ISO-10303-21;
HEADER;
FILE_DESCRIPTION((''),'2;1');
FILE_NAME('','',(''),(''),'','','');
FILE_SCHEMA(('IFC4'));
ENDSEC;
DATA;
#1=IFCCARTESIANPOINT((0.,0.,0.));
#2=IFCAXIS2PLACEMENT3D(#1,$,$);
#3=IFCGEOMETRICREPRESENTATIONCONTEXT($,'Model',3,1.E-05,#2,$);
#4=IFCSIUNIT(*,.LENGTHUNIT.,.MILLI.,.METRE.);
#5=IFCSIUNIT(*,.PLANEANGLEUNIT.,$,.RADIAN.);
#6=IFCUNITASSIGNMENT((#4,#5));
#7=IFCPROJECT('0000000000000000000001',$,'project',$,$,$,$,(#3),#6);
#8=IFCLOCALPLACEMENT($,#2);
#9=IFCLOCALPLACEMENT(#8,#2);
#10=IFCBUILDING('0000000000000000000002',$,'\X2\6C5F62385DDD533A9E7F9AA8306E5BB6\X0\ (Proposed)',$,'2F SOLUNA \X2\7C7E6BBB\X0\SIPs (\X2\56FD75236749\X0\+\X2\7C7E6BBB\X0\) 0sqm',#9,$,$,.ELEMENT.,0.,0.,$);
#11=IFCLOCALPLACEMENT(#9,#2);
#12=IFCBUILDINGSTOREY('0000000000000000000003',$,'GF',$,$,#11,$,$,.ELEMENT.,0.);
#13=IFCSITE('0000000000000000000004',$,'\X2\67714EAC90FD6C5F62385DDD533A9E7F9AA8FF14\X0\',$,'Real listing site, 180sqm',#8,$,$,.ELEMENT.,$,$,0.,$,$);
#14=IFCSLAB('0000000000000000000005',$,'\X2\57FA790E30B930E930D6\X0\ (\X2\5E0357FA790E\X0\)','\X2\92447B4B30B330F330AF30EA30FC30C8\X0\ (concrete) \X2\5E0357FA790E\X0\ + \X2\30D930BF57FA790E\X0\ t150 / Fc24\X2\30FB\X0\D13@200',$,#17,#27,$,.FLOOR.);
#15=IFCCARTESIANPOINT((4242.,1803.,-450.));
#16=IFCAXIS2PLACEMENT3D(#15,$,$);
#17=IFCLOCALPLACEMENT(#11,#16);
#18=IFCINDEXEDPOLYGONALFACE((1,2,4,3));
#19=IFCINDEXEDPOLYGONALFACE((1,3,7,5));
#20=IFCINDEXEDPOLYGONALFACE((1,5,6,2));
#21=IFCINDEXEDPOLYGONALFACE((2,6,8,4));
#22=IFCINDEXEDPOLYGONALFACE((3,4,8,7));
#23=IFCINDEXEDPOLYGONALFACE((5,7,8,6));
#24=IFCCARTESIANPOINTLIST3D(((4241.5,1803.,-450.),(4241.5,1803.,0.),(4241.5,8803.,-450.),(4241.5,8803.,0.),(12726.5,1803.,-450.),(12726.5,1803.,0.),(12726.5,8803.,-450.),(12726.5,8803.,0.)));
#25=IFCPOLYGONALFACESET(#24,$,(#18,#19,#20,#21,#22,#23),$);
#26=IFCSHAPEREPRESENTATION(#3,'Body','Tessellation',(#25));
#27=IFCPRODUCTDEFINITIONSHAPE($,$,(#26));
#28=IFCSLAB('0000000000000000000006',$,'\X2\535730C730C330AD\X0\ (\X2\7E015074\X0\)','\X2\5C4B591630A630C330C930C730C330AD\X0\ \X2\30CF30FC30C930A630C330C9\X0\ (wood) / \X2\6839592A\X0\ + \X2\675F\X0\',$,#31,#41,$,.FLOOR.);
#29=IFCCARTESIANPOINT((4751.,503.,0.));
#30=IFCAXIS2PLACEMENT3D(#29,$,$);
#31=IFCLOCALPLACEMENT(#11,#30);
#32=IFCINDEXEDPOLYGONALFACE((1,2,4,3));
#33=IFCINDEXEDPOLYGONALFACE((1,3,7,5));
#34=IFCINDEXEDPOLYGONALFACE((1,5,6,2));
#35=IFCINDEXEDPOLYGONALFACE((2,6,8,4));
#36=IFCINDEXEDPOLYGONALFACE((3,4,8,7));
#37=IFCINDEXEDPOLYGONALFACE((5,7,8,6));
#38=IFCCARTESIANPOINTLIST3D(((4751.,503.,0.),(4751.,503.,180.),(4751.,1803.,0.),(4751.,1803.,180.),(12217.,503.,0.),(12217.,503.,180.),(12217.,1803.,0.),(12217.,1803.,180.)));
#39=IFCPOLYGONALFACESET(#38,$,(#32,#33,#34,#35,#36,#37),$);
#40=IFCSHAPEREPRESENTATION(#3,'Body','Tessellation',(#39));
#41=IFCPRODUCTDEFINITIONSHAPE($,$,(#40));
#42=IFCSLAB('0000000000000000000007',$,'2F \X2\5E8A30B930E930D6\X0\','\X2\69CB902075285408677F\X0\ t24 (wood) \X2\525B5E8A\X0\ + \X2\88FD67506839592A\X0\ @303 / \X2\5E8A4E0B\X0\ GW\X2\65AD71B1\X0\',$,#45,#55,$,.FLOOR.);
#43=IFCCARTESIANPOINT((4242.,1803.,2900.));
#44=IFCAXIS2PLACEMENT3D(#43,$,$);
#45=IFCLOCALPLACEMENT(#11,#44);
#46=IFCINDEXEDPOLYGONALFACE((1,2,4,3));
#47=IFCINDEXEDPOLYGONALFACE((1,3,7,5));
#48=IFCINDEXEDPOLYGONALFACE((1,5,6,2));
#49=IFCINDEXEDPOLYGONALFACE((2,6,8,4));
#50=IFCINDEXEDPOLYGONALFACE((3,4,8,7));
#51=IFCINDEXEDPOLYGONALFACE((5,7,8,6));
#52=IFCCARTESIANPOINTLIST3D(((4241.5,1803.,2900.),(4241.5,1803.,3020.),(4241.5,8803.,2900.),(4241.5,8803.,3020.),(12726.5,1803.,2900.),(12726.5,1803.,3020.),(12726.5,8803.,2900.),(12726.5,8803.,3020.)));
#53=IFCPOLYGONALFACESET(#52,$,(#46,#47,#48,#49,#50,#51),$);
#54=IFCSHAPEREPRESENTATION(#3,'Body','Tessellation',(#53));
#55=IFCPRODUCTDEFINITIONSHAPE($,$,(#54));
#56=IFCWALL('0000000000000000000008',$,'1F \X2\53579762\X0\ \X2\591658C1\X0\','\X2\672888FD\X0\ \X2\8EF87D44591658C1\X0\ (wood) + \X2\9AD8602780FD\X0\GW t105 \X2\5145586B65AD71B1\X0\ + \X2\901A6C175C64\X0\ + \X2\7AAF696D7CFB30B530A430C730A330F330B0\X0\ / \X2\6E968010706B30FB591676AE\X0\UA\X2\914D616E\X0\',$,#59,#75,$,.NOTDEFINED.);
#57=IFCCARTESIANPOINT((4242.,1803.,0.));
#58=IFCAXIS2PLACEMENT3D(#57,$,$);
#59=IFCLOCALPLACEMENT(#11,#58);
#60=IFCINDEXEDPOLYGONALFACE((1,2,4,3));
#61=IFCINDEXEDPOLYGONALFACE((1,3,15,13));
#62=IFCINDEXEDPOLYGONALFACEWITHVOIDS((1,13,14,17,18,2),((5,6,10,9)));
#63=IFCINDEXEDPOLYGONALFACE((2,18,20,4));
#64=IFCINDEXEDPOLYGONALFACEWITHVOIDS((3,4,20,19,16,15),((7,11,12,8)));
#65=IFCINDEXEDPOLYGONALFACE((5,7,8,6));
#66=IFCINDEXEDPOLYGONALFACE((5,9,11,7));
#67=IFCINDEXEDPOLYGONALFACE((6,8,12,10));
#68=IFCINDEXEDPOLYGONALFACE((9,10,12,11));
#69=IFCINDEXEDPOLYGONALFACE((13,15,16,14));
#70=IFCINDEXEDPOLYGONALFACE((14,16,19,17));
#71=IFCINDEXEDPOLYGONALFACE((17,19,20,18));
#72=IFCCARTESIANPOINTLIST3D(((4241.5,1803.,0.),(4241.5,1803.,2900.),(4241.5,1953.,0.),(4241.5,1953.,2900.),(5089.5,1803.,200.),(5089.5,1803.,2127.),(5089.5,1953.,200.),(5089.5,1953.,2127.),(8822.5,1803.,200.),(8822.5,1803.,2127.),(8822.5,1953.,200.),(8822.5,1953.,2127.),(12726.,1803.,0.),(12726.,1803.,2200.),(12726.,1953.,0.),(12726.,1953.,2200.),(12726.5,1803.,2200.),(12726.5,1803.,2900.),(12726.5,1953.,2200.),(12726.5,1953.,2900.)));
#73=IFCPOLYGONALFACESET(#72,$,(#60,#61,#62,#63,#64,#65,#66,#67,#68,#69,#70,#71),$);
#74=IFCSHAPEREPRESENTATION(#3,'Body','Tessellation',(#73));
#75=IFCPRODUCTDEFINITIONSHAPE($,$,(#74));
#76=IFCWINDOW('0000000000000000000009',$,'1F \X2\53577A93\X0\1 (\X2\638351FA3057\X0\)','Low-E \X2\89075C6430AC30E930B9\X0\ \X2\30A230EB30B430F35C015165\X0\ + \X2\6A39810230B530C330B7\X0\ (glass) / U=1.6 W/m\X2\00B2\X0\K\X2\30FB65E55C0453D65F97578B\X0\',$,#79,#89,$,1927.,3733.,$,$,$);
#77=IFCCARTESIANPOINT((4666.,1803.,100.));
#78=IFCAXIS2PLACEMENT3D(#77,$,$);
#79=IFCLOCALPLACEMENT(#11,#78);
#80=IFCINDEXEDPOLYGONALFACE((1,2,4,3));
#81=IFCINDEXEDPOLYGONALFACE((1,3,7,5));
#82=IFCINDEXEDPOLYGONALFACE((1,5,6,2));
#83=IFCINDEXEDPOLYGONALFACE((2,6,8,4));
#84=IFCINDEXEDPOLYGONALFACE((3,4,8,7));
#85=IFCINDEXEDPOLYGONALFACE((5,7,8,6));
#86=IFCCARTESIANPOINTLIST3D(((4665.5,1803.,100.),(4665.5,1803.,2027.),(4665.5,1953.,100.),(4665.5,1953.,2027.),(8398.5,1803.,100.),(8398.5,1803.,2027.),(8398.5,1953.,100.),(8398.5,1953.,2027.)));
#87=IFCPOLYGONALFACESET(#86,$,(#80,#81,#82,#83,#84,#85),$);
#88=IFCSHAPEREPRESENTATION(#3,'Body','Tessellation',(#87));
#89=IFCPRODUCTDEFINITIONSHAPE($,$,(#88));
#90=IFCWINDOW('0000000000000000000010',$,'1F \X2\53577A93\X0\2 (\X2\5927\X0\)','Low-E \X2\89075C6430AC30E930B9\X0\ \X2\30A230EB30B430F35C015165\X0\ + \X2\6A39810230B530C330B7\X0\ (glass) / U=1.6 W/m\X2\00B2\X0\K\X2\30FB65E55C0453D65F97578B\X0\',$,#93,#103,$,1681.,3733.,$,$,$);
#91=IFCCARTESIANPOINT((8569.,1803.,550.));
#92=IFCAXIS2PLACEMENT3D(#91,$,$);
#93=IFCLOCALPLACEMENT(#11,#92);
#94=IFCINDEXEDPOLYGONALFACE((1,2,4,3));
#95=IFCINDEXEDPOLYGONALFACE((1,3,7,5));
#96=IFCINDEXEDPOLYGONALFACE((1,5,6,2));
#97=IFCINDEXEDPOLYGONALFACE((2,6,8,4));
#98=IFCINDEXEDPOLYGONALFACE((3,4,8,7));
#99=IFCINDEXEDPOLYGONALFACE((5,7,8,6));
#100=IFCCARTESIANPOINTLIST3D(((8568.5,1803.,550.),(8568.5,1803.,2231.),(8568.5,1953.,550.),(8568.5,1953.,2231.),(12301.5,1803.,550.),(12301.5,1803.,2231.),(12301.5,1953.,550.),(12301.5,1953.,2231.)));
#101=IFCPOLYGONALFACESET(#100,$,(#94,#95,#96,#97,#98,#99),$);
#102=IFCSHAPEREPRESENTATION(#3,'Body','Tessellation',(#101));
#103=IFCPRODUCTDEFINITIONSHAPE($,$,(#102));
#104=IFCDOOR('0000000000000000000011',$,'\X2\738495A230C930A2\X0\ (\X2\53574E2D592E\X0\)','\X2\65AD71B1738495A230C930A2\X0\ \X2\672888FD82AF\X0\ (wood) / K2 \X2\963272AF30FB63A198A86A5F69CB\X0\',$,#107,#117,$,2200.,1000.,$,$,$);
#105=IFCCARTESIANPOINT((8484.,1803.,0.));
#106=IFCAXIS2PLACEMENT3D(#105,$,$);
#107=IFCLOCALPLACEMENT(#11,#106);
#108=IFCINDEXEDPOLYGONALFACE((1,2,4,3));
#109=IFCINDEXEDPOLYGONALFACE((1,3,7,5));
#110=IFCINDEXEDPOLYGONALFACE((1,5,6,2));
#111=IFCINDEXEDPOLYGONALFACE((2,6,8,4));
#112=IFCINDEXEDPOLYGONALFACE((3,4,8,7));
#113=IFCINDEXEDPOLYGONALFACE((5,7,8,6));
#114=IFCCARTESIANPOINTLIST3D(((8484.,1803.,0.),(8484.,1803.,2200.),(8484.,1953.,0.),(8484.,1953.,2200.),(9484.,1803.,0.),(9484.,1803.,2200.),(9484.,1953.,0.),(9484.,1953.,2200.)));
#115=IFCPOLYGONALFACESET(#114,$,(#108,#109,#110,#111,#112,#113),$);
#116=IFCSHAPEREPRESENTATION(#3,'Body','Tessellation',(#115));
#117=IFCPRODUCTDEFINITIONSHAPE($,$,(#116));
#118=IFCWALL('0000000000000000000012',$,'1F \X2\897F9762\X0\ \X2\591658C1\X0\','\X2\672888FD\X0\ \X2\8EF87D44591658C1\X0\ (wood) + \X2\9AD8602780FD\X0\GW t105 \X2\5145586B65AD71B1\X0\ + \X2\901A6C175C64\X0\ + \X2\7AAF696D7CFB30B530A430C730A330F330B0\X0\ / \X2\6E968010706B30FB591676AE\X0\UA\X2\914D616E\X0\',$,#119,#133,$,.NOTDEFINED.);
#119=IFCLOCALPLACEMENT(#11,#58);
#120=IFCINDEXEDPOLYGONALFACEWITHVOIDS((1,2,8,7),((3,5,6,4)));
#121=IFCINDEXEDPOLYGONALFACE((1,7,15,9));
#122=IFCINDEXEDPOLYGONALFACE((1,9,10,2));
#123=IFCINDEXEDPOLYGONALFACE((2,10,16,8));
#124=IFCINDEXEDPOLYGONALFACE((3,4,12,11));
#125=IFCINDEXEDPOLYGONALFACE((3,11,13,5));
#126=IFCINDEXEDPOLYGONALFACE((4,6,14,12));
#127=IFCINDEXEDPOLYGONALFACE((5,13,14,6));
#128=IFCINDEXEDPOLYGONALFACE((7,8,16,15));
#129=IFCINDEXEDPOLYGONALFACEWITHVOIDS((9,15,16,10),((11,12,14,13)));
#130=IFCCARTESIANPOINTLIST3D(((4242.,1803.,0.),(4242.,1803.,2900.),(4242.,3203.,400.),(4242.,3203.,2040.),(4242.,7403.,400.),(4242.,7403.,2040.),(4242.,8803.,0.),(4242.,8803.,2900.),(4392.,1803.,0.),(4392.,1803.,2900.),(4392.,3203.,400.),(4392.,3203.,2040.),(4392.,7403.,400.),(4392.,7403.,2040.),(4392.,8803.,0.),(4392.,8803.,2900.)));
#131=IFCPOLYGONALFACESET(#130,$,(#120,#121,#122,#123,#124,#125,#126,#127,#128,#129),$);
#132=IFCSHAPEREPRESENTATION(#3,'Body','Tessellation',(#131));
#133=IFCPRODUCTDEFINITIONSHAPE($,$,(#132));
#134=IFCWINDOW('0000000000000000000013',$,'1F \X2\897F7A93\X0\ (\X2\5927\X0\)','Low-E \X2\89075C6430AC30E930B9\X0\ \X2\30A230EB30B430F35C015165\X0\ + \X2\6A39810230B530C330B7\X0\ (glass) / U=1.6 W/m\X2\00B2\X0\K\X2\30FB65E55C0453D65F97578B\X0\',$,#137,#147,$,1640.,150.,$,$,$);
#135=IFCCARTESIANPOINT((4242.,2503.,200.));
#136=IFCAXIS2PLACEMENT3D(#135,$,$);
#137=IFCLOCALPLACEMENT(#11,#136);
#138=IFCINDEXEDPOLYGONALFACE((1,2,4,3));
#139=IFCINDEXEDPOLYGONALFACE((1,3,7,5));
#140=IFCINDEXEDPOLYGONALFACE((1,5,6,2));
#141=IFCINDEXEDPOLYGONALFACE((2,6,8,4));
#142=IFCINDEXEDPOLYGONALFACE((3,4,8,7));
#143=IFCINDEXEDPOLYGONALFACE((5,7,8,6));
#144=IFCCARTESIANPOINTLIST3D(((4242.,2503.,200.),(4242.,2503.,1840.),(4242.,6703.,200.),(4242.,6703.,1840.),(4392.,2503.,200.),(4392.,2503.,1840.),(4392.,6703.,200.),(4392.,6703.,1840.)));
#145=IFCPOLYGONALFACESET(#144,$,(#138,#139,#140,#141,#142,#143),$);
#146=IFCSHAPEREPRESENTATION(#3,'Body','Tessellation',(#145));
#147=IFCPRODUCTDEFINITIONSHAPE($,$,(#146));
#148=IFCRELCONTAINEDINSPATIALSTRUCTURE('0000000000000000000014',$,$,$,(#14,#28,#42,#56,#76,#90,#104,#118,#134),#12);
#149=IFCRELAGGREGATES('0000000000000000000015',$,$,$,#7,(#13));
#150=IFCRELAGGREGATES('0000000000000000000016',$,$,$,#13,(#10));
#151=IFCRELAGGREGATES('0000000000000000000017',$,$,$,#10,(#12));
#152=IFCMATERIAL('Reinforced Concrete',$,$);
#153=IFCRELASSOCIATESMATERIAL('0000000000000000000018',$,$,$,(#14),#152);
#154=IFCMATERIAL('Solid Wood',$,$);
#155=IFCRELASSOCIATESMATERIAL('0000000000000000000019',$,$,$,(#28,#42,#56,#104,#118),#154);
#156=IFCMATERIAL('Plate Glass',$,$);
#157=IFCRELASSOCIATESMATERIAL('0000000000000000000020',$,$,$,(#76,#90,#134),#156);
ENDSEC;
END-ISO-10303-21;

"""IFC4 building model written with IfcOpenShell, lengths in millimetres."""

from ifc_helpers import new_model, si_unit, frame, frame_2d, origin, place, context, project, spatial, rectangle, extrude, material, element, fill, save


model = new_model("IFC4")

# Units and contexts
model_context = context("Model", 3, precision=1e-05, world=origin())
ifc_project = project(units=[si_unit("LENGTHUNIT", "METRE", prefix="MILLI"), si_unit("PLANEANGLEUNIT", "RADIAN")], contexts=[model_context])

# Site, building, storey
site_placement = place(None, origin())
site = spatial("IfcSite", under=ifc_project, at=site_placement, Name="東京都江戸川区鹿骨４", ObjectType="Real listing site, 180sqm", CompositionType="ELEMENT", RefElevation=0.0)
building_placement = place(site_placement, origin())
building = spatial("IfcBuilding", under=site, at=building_placement, Name="江戸川区鹿骨の家 (Proposed)", ObjectType="2F SOLUNA 籾殻SIPs (国産杉+籾殻) 0sqm", CompositionType="ELEMENT", ElevationOfRefHeight=0.0, ElevationOfTerrain=0.0)
storey_placement = place(building_placement, origin())
storey = spatial("IfcBuildingStorey", under=building, at=storey_placement, Name="GF", CompositionType="ELEMENT", Elevation=0.0)

# Slabs
ifc_material_1 = material(Name="Reinforced Concrete")
slab_1_placement = place(storey_placement, frame((4242.0, 1803.0, -450.0)))
element("IfcSlab", 1, at=slab_1_placement, inside=storey, material=ifc_material_1, Name="基礎スラブ (布基礎)", Description="鉄筋コンクリート (concrete) 布基礎 + ベタ基礎 t150 / Fc24・D13@200", PredefinedType="FLOOR", context=model_context, shape_type="SweptSolid", body=[
    extrude(rectangle(XDim=8485.0, YDim=7000.0, at=frame_2d((4242.0, 3500.0))), frame((4242.0, 1803.0, -450.0)), (0.0, 0.0, 1.0), 450.0),
])
ifc_material_2 = material(Name="Solid Wood")
slab_2_placement = place(storey_placement, frame((4751.0, 503.0, 0.0)))
element("IfcSlab", 2, at=slab_2_placement, inside=storey, material=ifc_material_2, Name="南デッキ (縁側)", Description="屋外ウッドデッキ ハードウッド (wood) / 根太 + 束", PredefinedType="FLOOR", context=model_context, shape_type="SweptSolid", body=[
    extrude(rectangle(XDim=7466.0, YDim=1300.0, at=frame_2d((3733.0, 650.0))), frame((4751.0, 503.0, 0.0)), (0.0, 0.0, 1.0), 180.0),
])
slab_3_placement = place(storey_placement, frame((4242.0, 1803.0, 2900.0)))
element("IfcSlab", 3, at=slab_3_placement, inside=storey, material=ifc_material_2, Name="2F 床スラブ", Description="構造用合板 t24 (wood) 剛床 + 製材根太 @303 / 床下 GW断熱", PredefinedType="FLOOR", context=model_context, shape_type="SweptSolid", body=[
    extrude(rectangle(XDim=8485.0, YDim=7000.0, at=frame_2d((4242.0, 3500.0))), frame((4242.0, 1803.0, 2900.0)), (0.0, 0.0, 1.0), 120.0),
])

# Wall, openings, windows, door
wall_1_placement = place(storey_placement, frame((4242.0, 1803.0, 0.0)))
wall_1 = element("IfcWall", 4, at=wall_1_placement, inside=storey, material=ifc_material_2, Name="1F 南面 外壁", Description="木製 軸組外壁 (wood) + 高性能GW t105 充填断熱 + 通気層 + 窯業系サイディング / 準耐火・外皮UA配慮", PredefinedType="NOTDEFINED", context=model_context, shape_type="SweptSolid", body=[
    extrude(rectangle(XDim=8485.0, YDim=150.0, at=frame_2d((4242.0, 75.0))), frame((4242.0, 1803.0, 0.0)), (0.0, 0.0, 1.0), 2900.0),
])
opening_1_placement = place(storey_placement, frame((4666.0, 1803.0, 100.0)))
opening_1 = element("IfcOpeningElement", 5, at=opening_1_placement, cuts=wall_1, PredefinedType="NOTDEFINED", context=model_context, shape_type="SweptSolid", body=[
    extrude(rectangle(XDim=3733.0, YDim=150.0, at=frame_2d((1866.0, 75.0))), frame((4666.0, 1803.0, 100.0)), (0.0, 0.0, 1.0), 1927.0),
])
opening_2_placement = place(storey_placement, frame((8569.0, 1803.0, 550.0)))
opening_2 = element("IfcOpeningElement", 6, at=opening_2_placement, cuts=wall_1, PredefinedType="NOTDEFINED", context=model_context, shape_type="SweptSolid", body=[
    extrude(rectangle(XDim=3733.0, YDim=150.0, at=frame_2d((1866.0, 75.0))), frame((8569.0, 1803.0, 550.0)), (0.0, 0.0, 1.0), 1681.0),
])
opening_3_placement = place(storey_placement, frame((8484.0, 1803.0, 0.0)))
opening_3 = element("IfcOpeningElement", 7, at=opening_3_placement, cuts=wall_1, PredefinedType="NOTDEFINED", context=model_context, shape_type="SweptSolid", body=[
    extrude(rectangle(XDim=1000.0, YDim=150.0, at=frame_2d((500.0, 75.0))), frame((8484.0, 1803.0, 0.0)), (0.0, 0.0, 1.0), 2200.0),
])
ifc_material_3 = material(Name="Plate Glass")
window_1_placement = place(storey_placement, frame((4666.0, 1803.0, 100.0)))
window_1 = element("IfcWindow", 8, at=window_1_placement, inside=storey, material=ifc_material_3, Name="1F 南窓1 (掃出し)", Description="Low-E 複層ガラス アルゴン封入 + 樹脂サッシ (glass) / U=1.6 W/m²K・日射取得型", OverallHeight=1927.0, OverallWidth=3733.0, context=model_context, shape_type="SweptSolid", body=[
    extrude(rectangle(XDim=3733.0, YDim=150.0, at=frame_2d((1866.0, 75.0))), frame((4666.0, 1803.0, 100.0)), (0.0, 0.0, 1.0), 1927.0),
])
fill(opening_1, window_1)
window_2_placement = place(storey_placement, frame((8569.0, 1803.0, 550.0)))
window_2 = element("IfcWindow", 9, at=window_2_placement, inside=storey, material=ifc_material_3, Name="1F 南窓2 (大)", Description="Low-E 複層ガラス アルゴン封入 + 樹脂サッシ (glass) / U=1.6 W/m²K・日射取得型", OverallHeight=1681.0, OverallWidth=3733.0, context=model_context, shape_type="SweptSolid", body=[
    extrude(rectangle(XDim=3733.0, YDim=150.0, at=frame_2d((1866.0, 75.0))), frame((8569.0, 1803.0, 550.0)), (0.0, 0.0, 1.0), 1681.0),
])
fill(opening_2, window_2)
door_placement = place(storey_placement, frame((8484.0, 1803.0, 0.0)))
door = element("IfcDoor", 10, at=door_placement, inside=storey, material=ifc_material_2, Name="玄関ドア (南中央)", Description="断熱玄関ドア 木製芯 (wood) / K2 防犯・採風機構", OverallHeight=2200.0, OverallWidth=1000.0, context=model_context, shape_type="SweptSolid", body=[
    extrude(rectangle(XDim=1000.0, YDim=150.0, at=frame_2d((500.0, 75.0))), frame((8484.0, 1803.0, 0.0)), (0.0, 0.0, 1.0), 2200.0),
])
fill(opening_3, door)

# Wall, opening, window
wall_2_placement = place(storey_placement, frame((4242.0, 1803.0, 0.0)))
wall_2 = element("IfcWall", 11, at=wall_2_placement, inside=storey, material=ifc_material_2, Name="1F 西面 外壁", Description="木製 軸組外壁 (wood) + 高性能GW t105 充填断熱 + 通気層 + 窯業系サイディング / 準耐火・外皮UA配慮", PredefinedType="NOTDEFINED", context=model_context, shape_type="SweptSolid", body=[
    extrude(rectangle(XDim=150.0, YDim=7000.0, at=frame_2d((75.0, 3500.0))), frame((4242.0, 1803.0, 0.0)), (0.0, 0.0, 1.0), 2900.0),
])
opening_4_placement = place(storey_placement, frame((4242.0, 2503.0, 200.0)))
opening_4 = element("IfcOpeningElement", 12, at=opening_4_placement, cuts=wall_2, PredefinedType="NOTDEFINED", context=model_context, shape_type="SweptSolid", body=[
    extrude(rectangle(XDim=150.0, YDim=4200.0, at=frame_2d((75.0, 2100.0))), frame((4242.0, 2503.0, 200.0)), (0.0, 0.0, 1.0), 1640.0),
])
window_3_placement = place(storey_placement, frame((4242.0, 2503.0, 200.0)))
window_3 = element("IfcWindow", 13, at=window_3_placement, inside=storey, material=ifc_material_3, Name="1F 西窓 (大)", Description="Low-E 複層ガラス アルゴン封入 + 樹脂サッシ (glass) / U=1.6 W/m²K・日射取得型", OverallHeight=1640.0, OverallWidth=150.0, context=model_context, shape_type="SweptSolid", body=[
    extrude(rectangle(XDim=150.0, YDim=4200.0, at=frame_2d((75.0, 2100.0))), frame((4242.0, 2503.0, 200.0)), (0.0, 0.0, 1.0), 1640.0),
])
fill(opening_4, window_3)

save(model, "model.ifc")
